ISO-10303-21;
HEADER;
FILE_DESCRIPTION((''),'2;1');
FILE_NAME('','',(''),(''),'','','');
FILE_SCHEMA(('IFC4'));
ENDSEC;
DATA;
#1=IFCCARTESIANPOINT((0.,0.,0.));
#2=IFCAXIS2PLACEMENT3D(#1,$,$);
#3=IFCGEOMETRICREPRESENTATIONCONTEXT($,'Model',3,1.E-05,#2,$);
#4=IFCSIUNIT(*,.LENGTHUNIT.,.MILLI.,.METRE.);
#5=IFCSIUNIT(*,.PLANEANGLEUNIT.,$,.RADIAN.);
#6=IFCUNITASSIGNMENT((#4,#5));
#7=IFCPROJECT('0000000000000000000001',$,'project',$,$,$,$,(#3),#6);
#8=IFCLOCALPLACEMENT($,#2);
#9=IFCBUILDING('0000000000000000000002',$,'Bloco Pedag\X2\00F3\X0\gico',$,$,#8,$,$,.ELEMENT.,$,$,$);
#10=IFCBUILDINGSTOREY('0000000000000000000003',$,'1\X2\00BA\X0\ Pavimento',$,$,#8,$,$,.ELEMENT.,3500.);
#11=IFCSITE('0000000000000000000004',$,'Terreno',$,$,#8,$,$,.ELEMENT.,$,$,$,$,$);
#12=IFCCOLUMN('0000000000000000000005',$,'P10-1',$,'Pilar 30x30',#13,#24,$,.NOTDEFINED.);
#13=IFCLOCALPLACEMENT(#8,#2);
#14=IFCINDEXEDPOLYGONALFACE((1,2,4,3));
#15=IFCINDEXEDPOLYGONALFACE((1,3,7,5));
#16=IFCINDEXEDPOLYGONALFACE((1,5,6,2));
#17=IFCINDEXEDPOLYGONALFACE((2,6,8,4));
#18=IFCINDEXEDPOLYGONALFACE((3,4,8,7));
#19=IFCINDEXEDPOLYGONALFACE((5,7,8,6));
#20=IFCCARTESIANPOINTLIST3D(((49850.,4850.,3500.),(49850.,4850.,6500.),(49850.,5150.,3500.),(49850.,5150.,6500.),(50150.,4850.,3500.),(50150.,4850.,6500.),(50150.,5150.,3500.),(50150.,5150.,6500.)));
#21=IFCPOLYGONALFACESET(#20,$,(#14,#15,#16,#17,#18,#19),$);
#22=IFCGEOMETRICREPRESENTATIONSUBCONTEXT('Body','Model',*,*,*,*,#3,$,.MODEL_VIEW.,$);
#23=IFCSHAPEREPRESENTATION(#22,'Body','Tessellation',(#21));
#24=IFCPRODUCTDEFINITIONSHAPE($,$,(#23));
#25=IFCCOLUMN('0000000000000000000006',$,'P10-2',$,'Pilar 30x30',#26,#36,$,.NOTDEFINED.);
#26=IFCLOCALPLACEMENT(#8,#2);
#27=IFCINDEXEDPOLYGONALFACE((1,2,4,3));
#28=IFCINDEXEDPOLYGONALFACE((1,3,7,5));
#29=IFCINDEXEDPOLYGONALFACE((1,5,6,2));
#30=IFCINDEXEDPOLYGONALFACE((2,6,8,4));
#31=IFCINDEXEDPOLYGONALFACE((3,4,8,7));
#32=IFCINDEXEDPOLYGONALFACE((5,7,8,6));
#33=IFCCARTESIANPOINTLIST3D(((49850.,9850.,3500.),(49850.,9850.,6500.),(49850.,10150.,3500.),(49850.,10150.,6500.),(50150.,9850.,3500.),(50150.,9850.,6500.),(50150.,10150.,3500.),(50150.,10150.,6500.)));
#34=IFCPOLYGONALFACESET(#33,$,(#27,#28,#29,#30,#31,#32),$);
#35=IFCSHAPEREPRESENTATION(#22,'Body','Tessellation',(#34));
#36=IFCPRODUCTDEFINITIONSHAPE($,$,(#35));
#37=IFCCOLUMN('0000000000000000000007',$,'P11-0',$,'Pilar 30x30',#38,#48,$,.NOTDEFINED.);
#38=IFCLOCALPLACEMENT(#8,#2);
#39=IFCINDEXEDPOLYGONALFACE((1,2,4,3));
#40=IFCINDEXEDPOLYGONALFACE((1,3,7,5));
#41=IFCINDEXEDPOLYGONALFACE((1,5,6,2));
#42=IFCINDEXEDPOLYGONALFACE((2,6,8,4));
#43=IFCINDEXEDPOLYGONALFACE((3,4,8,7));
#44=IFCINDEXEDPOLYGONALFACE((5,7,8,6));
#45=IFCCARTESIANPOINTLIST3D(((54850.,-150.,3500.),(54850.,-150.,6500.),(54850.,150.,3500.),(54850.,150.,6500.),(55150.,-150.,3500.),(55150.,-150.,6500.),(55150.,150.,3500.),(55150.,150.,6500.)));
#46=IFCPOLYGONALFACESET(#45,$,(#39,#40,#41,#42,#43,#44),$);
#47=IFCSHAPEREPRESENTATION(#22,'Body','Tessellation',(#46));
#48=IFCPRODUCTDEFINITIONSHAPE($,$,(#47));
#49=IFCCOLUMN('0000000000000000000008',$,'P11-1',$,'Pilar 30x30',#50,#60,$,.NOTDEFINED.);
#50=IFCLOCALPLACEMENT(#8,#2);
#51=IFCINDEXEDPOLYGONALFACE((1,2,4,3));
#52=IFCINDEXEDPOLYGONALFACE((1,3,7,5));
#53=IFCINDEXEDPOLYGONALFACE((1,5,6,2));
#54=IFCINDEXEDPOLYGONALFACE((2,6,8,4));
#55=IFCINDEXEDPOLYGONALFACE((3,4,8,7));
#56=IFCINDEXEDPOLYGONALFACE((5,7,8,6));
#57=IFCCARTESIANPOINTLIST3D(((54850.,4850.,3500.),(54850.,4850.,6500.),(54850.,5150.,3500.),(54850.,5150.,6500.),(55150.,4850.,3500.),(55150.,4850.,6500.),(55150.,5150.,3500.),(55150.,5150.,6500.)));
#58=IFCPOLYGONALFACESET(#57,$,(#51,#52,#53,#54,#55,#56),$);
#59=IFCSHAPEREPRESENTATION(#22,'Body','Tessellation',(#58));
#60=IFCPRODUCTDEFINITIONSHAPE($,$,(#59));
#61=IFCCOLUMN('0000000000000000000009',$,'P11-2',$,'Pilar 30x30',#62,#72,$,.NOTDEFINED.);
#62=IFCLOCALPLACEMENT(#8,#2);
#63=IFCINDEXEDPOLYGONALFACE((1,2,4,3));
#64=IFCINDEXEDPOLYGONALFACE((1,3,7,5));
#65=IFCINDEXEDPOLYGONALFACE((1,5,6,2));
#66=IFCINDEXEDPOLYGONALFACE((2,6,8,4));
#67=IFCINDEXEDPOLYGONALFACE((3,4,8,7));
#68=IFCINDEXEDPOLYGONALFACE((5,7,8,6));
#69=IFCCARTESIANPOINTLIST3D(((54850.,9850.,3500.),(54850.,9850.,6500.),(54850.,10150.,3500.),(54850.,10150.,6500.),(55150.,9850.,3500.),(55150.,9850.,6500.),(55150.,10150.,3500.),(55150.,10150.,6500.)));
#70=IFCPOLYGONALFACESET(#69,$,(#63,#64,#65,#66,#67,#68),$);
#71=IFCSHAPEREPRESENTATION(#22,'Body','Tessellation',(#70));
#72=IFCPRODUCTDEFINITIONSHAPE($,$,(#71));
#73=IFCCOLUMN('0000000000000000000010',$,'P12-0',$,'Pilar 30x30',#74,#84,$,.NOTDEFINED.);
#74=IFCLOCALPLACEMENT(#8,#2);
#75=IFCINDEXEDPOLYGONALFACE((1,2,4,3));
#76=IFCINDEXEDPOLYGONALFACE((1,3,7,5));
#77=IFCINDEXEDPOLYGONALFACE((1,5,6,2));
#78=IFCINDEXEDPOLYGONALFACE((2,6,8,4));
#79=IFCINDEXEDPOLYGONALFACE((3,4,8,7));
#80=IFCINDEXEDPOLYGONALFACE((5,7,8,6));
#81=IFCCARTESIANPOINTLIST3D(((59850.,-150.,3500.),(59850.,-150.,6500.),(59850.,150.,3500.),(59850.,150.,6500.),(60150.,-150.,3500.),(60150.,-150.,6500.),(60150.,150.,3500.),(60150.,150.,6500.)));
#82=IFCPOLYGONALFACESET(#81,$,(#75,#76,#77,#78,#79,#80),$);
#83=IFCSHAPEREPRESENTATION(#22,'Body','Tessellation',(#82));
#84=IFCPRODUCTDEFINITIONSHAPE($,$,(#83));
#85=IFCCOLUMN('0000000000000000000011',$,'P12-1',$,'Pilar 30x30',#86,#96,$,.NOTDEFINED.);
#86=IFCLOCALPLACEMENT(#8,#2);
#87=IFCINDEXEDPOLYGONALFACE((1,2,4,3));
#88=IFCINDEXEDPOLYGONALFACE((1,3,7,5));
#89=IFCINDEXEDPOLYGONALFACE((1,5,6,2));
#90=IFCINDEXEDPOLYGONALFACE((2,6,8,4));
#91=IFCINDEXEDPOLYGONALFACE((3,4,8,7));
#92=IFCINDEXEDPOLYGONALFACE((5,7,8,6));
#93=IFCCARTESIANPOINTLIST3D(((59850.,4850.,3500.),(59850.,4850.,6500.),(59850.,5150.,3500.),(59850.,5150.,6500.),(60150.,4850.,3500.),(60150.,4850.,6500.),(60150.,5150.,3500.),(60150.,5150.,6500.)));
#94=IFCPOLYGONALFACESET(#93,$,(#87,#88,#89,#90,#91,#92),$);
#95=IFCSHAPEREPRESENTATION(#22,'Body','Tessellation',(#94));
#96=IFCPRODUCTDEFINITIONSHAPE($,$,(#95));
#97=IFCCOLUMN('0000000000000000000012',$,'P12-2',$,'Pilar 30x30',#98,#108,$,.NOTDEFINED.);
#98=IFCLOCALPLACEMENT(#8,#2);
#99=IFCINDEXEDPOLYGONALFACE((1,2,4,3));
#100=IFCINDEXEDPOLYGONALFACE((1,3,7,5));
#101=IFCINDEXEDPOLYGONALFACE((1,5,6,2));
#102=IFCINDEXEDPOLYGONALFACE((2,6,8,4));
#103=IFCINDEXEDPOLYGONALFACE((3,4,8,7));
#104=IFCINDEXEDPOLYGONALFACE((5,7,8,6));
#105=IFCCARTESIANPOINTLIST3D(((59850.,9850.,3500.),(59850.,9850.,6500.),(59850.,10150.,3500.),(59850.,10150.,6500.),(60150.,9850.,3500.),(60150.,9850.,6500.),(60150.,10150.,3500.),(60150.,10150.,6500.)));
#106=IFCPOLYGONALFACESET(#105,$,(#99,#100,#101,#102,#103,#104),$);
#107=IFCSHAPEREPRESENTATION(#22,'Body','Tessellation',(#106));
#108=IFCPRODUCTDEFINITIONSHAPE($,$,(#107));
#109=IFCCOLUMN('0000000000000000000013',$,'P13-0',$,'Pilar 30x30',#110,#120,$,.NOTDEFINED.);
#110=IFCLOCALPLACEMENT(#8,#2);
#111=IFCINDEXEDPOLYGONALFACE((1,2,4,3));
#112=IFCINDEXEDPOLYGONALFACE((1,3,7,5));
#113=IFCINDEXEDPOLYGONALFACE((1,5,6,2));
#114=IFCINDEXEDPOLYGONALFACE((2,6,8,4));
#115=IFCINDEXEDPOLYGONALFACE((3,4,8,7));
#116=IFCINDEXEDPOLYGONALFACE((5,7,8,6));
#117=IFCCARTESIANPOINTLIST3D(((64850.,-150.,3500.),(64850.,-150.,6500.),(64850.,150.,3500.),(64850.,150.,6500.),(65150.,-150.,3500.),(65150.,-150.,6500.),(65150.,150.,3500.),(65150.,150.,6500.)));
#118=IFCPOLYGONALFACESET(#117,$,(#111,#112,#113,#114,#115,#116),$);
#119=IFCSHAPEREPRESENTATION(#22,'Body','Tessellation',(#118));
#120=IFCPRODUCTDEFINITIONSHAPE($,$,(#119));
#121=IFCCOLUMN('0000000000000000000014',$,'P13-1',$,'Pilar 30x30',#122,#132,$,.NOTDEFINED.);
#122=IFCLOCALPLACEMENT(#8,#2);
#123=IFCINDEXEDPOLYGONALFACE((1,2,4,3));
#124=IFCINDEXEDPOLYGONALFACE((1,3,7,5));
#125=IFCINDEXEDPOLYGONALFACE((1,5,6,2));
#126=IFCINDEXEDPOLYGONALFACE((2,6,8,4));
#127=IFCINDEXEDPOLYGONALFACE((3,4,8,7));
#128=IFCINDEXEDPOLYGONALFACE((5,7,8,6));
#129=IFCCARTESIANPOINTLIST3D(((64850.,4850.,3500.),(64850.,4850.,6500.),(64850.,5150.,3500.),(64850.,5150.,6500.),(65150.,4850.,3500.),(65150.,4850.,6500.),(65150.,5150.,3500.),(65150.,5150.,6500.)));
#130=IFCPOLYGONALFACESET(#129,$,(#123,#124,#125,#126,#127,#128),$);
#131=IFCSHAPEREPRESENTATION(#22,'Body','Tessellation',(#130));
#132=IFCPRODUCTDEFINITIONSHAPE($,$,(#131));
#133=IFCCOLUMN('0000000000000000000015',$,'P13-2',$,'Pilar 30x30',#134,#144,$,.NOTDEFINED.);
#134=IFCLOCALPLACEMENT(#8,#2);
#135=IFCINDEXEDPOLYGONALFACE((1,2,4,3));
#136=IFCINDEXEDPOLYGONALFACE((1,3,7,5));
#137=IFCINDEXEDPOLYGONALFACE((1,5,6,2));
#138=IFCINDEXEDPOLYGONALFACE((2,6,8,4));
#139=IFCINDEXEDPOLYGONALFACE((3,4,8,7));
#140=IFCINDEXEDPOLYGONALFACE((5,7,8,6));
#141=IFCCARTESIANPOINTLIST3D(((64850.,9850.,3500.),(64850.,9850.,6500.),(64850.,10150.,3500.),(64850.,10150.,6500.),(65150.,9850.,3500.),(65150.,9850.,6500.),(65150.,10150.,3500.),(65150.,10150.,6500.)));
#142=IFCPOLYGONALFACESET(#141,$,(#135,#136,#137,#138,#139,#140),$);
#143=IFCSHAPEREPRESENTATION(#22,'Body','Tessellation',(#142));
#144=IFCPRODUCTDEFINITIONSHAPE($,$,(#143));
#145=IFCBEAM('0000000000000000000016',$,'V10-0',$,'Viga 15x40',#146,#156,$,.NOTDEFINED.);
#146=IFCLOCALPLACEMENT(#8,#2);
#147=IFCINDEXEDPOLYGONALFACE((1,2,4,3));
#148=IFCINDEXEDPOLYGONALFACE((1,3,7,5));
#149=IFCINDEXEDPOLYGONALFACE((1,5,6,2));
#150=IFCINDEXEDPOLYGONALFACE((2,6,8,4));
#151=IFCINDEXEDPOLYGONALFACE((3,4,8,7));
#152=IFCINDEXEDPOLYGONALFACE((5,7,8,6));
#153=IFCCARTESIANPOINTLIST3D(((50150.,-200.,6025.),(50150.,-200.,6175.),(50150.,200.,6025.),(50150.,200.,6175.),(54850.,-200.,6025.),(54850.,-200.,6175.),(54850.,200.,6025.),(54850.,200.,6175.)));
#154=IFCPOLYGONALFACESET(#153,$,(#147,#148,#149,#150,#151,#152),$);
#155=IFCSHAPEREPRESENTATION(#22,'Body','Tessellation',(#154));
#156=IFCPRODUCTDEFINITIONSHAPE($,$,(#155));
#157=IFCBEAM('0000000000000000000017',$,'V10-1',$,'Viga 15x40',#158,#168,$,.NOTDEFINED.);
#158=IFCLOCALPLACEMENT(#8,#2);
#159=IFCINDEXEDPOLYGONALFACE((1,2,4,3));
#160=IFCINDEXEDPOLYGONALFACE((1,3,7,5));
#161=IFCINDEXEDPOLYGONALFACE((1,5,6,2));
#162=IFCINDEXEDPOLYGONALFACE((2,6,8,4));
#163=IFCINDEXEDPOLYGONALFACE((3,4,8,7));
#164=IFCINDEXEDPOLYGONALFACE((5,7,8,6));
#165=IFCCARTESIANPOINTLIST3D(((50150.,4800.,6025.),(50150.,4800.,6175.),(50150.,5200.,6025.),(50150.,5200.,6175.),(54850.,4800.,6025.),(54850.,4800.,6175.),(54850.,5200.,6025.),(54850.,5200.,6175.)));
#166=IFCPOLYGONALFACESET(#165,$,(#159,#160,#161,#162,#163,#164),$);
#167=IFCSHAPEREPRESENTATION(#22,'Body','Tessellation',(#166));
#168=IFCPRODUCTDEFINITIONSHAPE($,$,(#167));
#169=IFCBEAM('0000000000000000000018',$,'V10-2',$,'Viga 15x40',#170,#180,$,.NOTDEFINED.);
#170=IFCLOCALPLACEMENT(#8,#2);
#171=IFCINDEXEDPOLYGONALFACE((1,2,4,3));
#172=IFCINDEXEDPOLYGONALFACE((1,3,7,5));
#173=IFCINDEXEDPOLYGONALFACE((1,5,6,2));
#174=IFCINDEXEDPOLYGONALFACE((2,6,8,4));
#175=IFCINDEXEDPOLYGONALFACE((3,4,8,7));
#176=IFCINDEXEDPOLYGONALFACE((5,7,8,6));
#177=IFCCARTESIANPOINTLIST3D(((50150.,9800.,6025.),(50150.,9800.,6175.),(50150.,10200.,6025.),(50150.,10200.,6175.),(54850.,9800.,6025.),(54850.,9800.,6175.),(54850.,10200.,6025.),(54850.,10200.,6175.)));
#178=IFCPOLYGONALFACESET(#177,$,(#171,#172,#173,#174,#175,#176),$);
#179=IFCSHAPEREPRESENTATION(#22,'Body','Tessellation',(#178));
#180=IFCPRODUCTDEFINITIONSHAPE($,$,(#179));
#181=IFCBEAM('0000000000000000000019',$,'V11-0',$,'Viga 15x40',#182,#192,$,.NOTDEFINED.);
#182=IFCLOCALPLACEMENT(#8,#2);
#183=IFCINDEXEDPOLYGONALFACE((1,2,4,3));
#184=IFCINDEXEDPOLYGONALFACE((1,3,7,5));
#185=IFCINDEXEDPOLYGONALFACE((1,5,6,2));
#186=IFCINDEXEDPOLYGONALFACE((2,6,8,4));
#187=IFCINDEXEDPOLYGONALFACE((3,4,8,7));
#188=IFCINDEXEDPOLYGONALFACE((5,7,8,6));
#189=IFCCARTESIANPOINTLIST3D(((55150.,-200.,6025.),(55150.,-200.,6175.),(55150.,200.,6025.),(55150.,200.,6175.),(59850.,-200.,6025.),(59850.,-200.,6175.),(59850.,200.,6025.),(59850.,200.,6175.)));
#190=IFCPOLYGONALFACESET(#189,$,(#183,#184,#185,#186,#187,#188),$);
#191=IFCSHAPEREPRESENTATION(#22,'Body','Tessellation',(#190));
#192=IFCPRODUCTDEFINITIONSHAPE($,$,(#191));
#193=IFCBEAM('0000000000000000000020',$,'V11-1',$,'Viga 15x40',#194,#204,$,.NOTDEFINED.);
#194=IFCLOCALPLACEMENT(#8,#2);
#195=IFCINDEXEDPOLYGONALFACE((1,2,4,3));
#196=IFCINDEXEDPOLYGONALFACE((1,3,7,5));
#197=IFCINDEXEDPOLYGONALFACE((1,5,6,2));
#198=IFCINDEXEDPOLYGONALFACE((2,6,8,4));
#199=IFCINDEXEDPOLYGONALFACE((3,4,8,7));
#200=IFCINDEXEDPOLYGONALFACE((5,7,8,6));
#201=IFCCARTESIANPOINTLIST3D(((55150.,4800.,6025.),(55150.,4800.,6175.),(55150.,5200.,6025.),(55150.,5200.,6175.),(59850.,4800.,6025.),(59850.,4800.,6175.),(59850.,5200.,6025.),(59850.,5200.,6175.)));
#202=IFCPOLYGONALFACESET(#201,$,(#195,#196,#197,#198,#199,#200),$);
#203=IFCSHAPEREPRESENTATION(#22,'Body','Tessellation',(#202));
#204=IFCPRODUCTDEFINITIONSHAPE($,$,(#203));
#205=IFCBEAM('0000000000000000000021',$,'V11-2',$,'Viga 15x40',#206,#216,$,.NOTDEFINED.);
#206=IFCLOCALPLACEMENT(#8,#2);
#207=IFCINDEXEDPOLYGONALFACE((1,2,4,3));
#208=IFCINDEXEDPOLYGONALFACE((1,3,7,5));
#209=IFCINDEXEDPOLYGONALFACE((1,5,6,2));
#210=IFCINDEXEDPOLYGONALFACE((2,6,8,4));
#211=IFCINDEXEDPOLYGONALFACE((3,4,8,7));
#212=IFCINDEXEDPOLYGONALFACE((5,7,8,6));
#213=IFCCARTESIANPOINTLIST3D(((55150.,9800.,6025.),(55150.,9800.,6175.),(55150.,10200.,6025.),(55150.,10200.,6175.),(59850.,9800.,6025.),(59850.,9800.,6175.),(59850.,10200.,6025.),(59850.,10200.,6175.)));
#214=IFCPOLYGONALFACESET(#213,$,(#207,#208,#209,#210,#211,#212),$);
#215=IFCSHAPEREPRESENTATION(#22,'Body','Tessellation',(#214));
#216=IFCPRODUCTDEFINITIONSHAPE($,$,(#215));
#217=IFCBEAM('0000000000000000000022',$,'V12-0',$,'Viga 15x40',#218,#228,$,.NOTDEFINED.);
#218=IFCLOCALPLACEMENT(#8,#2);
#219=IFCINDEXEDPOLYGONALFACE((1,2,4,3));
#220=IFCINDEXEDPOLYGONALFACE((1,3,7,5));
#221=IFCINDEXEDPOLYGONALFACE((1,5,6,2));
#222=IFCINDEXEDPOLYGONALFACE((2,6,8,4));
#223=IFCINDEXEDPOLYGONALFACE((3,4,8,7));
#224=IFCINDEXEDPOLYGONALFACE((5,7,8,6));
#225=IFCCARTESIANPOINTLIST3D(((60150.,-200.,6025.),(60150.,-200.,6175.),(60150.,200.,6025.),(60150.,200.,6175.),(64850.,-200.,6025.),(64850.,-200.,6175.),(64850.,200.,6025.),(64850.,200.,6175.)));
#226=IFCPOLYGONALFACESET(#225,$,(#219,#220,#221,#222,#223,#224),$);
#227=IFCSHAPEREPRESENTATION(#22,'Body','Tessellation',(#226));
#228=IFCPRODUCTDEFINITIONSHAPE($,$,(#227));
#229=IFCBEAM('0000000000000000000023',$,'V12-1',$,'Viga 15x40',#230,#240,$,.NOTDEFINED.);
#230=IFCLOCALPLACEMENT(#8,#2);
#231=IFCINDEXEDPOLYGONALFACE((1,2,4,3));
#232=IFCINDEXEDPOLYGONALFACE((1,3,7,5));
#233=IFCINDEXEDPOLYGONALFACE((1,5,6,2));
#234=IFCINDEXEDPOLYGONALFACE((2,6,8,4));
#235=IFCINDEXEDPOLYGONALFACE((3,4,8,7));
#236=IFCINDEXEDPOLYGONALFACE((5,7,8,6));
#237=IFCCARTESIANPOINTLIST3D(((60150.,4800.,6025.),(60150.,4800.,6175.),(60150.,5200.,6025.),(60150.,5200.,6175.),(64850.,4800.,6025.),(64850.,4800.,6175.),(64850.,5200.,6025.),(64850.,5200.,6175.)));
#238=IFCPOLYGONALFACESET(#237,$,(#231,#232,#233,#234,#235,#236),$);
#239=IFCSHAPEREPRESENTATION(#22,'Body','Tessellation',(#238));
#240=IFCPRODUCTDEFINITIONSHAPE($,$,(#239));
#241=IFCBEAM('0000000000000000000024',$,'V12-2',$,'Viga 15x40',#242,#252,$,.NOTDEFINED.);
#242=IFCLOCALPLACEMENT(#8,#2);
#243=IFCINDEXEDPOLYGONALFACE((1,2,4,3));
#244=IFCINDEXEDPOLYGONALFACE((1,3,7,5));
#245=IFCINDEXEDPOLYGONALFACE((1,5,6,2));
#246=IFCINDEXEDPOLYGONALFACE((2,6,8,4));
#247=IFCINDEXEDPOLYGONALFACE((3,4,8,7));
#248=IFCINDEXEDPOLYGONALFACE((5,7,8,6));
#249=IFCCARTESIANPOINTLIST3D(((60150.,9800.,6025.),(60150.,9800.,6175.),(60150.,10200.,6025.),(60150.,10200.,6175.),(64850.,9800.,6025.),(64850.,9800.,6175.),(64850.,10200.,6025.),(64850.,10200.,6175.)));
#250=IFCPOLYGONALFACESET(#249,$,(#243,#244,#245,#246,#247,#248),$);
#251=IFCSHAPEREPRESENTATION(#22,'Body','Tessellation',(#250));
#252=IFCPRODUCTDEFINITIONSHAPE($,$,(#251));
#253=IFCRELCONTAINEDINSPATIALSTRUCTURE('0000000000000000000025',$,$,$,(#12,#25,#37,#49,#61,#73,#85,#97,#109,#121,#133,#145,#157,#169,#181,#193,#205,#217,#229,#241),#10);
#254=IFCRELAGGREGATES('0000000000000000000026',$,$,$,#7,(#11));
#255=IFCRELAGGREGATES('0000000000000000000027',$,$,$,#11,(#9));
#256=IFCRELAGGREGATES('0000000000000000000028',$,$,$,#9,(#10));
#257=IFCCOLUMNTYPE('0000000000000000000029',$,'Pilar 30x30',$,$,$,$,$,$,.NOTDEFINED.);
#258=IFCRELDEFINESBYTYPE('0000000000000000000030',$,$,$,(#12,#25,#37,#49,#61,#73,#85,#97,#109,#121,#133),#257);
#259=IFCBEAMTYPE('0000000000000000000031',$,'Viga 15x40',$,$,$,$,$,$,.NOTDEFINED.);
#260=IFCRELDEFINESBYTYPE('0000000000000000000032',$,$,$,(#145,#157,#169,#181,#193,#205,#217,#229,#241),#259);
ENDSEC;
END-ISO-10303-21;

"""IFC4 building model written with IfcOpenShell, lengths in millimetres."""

from ifc_helpers import new_model, si_unit, frame, origin, origin_2d, place, context, subcontext, project, spatial, rectangle, extrude, type_object, element, save


model = new_model("IFC4")

# Units and contexts
model_context = context("Model", 3, precision=1e-05, world=origin())
body_context = subcontext(model_context, "Body", "Model", "MODEL_VIEW")
ifc_project = project(units=[si_unit("LENGTHUNIT", "METRE", prefix="MILLI"), si_unit("PLANEANGLEUNIT", "RADIAN")], contexts=[model_context])

# Site, building, storey
placement = place(None, origin())
site = spatial("IfcSite", under=ifc_project, at=placement, Name="Terreno", CompositionType="ELEMENT")
building = spatial("IfcBuilding", under=site, at=placement, Name="Bloco Pedagógico", CompositionType="ELEMENT")
storey = spatial("IfcBuildingStorey", under=building, at=placement, Name="1º Pavimento", CompositionType="ELEMENT", Elevation=3500.0)

# Columns
column_type = type_object("IfcColumnType", Name="Pilar 30x30", PredefinedType="NOTDEFINED")
for number, where, z_axis, x_axis, name in (
    (1, (50000.0, 5000.0, 3500.0), (0.0, 0.0, 1.0), (1.0, 0.0, 0.0), "P10-1"),
    (2, (50000.0, 10000.0, 3500.0), (0.0, 0.0, 1.0), (1.0, 0.0, 0.0), "P10-2"),
    (3, (55000.0, 0.0, 3500.0), (0.0, 0.0, 1.0), (1.0, 0.0, 0.0), "P11-0"),
    (4, (55000.0, 5000.0, 3500.0), (0.0, 0.0, 1.0), (1.0, 0.0, 0.0), "P11-1"),
    (5, (55000.0, 10000.0, 3500.0), (0.0, 0.0, 1.0), (1.0, 0.0, 0.0), "P11-2"),
    (6, (60000.0, 0.0, 3500.0), (0.0, 0.0, 1.0), (1.0, 0.0, 0.0), "P12-0"),
    (7, (60000.0, 5000.0, 3500.0), (0.0, 0.0, 1.0), (1.0, 0.0, 0.0), "P12-1"),
    (8, (60000.0, 10000.0, 3500.0), (0.0, 0.0, 1.0), (1.0, 0.0, 0.0), "P12-2"),
    (9, (65000.0, 0.0, 3500.0), (0.0, 0.0, 1.0), (1.0, 0.0, 0.0), "P13-0"),
    (10, (65000.0, 5000.0, 3500.0), (0.0, 0.0, 1.0), (1.0, 0.0, 0.0), "P13-1"),
    (11, (65000.0, 10000.0, 3500.0), (0.0, 0.0, 1.0), (1.0, 0.0, 0.0), "P13-2"),
):
    element("IfcColumn", number, at=place(None, frame(where, z_axis=z_axis, x_axis=x_axis)), inside=storey, type_object=column_type, Name=name, ObjectType="Pilar 30x30", PredefinedType="NOTDEFINED", context=body_context, shape_type="SweptSolid", body=[
        extrude(rectangle(XDim=300.0, YDim=300.0, at=origin_2d()), None, (0.0, 0.0, 1.0), 3000.0),
    ])

# Beams
beam_type = type_object("IfcBeamType", Name="Viga 15x40", PredefinedType="NOTDEFINED")
for number, where, z_axis, x_axis, name in (
    (12, (50150.0, 0.0, 6100.0), (1.0, 0.0, 0.0), (0.0, 1.0, 0.0), "V10-0"),
    (13, (50150.0, 5000.0, 6100.0), (1.0, 0.0, 0.0), (0.0, 1.0, 0.0), "V10-1"),
    (14, (50150.0, 10000.0, 6100.0), (1.0, 0.0, 0.0), (0.0, 1.0, 0.0), "V10-2"),
    (15, (55150.0, 0.0, 6100.0), (1.0, 0.0, 0.0), (0.0, 1.0, 0.0), "V11-0"),
    (16, (55150.0, 5000.0, 6100.0), (1.0, 0.0, 0.0), (0.0, 1.0, 0.0), "V11-1"),
    (17, (55150.0, 10000.0, 6100.0), (1.0, 0.0, 0.0), (0.0, 1.0, 0.0), "V11-2"),
    (18, (60150.0, 0.0, 6100.0), (1.0, 0.0, 0.0), (0.0, 1.0, 0.0), "V12-0"),
    (19, (60150.0, 5000.0, 6100.0), (1.0, 0.0, 0.0), (0.0, 1.0, 0.0), "V12-1"),
    (20, (60150.0, 10000.0, 6100.0), (1.0, 0.0, 0.0), (0.0, 1.0, 0.0), "V12-2"),
):
    element("IfcBeam", number, at=place(None, frame(where, z_axis=z_axis, x_axis=x_axis)), inside=storey, type_object=beam_type, Name=name, ObjectType="Viga 15x40", PredefinedType="NOTDEFINED", context=body_context, shape_type="SweptSolid", body=[
        extrude(rectangle(XDim=400.0, YDim=150.0, at=origin_2d()), None, (0.0, 0.0, 1.0), 4700.0),
    ])

save(model, "model.ifc")
